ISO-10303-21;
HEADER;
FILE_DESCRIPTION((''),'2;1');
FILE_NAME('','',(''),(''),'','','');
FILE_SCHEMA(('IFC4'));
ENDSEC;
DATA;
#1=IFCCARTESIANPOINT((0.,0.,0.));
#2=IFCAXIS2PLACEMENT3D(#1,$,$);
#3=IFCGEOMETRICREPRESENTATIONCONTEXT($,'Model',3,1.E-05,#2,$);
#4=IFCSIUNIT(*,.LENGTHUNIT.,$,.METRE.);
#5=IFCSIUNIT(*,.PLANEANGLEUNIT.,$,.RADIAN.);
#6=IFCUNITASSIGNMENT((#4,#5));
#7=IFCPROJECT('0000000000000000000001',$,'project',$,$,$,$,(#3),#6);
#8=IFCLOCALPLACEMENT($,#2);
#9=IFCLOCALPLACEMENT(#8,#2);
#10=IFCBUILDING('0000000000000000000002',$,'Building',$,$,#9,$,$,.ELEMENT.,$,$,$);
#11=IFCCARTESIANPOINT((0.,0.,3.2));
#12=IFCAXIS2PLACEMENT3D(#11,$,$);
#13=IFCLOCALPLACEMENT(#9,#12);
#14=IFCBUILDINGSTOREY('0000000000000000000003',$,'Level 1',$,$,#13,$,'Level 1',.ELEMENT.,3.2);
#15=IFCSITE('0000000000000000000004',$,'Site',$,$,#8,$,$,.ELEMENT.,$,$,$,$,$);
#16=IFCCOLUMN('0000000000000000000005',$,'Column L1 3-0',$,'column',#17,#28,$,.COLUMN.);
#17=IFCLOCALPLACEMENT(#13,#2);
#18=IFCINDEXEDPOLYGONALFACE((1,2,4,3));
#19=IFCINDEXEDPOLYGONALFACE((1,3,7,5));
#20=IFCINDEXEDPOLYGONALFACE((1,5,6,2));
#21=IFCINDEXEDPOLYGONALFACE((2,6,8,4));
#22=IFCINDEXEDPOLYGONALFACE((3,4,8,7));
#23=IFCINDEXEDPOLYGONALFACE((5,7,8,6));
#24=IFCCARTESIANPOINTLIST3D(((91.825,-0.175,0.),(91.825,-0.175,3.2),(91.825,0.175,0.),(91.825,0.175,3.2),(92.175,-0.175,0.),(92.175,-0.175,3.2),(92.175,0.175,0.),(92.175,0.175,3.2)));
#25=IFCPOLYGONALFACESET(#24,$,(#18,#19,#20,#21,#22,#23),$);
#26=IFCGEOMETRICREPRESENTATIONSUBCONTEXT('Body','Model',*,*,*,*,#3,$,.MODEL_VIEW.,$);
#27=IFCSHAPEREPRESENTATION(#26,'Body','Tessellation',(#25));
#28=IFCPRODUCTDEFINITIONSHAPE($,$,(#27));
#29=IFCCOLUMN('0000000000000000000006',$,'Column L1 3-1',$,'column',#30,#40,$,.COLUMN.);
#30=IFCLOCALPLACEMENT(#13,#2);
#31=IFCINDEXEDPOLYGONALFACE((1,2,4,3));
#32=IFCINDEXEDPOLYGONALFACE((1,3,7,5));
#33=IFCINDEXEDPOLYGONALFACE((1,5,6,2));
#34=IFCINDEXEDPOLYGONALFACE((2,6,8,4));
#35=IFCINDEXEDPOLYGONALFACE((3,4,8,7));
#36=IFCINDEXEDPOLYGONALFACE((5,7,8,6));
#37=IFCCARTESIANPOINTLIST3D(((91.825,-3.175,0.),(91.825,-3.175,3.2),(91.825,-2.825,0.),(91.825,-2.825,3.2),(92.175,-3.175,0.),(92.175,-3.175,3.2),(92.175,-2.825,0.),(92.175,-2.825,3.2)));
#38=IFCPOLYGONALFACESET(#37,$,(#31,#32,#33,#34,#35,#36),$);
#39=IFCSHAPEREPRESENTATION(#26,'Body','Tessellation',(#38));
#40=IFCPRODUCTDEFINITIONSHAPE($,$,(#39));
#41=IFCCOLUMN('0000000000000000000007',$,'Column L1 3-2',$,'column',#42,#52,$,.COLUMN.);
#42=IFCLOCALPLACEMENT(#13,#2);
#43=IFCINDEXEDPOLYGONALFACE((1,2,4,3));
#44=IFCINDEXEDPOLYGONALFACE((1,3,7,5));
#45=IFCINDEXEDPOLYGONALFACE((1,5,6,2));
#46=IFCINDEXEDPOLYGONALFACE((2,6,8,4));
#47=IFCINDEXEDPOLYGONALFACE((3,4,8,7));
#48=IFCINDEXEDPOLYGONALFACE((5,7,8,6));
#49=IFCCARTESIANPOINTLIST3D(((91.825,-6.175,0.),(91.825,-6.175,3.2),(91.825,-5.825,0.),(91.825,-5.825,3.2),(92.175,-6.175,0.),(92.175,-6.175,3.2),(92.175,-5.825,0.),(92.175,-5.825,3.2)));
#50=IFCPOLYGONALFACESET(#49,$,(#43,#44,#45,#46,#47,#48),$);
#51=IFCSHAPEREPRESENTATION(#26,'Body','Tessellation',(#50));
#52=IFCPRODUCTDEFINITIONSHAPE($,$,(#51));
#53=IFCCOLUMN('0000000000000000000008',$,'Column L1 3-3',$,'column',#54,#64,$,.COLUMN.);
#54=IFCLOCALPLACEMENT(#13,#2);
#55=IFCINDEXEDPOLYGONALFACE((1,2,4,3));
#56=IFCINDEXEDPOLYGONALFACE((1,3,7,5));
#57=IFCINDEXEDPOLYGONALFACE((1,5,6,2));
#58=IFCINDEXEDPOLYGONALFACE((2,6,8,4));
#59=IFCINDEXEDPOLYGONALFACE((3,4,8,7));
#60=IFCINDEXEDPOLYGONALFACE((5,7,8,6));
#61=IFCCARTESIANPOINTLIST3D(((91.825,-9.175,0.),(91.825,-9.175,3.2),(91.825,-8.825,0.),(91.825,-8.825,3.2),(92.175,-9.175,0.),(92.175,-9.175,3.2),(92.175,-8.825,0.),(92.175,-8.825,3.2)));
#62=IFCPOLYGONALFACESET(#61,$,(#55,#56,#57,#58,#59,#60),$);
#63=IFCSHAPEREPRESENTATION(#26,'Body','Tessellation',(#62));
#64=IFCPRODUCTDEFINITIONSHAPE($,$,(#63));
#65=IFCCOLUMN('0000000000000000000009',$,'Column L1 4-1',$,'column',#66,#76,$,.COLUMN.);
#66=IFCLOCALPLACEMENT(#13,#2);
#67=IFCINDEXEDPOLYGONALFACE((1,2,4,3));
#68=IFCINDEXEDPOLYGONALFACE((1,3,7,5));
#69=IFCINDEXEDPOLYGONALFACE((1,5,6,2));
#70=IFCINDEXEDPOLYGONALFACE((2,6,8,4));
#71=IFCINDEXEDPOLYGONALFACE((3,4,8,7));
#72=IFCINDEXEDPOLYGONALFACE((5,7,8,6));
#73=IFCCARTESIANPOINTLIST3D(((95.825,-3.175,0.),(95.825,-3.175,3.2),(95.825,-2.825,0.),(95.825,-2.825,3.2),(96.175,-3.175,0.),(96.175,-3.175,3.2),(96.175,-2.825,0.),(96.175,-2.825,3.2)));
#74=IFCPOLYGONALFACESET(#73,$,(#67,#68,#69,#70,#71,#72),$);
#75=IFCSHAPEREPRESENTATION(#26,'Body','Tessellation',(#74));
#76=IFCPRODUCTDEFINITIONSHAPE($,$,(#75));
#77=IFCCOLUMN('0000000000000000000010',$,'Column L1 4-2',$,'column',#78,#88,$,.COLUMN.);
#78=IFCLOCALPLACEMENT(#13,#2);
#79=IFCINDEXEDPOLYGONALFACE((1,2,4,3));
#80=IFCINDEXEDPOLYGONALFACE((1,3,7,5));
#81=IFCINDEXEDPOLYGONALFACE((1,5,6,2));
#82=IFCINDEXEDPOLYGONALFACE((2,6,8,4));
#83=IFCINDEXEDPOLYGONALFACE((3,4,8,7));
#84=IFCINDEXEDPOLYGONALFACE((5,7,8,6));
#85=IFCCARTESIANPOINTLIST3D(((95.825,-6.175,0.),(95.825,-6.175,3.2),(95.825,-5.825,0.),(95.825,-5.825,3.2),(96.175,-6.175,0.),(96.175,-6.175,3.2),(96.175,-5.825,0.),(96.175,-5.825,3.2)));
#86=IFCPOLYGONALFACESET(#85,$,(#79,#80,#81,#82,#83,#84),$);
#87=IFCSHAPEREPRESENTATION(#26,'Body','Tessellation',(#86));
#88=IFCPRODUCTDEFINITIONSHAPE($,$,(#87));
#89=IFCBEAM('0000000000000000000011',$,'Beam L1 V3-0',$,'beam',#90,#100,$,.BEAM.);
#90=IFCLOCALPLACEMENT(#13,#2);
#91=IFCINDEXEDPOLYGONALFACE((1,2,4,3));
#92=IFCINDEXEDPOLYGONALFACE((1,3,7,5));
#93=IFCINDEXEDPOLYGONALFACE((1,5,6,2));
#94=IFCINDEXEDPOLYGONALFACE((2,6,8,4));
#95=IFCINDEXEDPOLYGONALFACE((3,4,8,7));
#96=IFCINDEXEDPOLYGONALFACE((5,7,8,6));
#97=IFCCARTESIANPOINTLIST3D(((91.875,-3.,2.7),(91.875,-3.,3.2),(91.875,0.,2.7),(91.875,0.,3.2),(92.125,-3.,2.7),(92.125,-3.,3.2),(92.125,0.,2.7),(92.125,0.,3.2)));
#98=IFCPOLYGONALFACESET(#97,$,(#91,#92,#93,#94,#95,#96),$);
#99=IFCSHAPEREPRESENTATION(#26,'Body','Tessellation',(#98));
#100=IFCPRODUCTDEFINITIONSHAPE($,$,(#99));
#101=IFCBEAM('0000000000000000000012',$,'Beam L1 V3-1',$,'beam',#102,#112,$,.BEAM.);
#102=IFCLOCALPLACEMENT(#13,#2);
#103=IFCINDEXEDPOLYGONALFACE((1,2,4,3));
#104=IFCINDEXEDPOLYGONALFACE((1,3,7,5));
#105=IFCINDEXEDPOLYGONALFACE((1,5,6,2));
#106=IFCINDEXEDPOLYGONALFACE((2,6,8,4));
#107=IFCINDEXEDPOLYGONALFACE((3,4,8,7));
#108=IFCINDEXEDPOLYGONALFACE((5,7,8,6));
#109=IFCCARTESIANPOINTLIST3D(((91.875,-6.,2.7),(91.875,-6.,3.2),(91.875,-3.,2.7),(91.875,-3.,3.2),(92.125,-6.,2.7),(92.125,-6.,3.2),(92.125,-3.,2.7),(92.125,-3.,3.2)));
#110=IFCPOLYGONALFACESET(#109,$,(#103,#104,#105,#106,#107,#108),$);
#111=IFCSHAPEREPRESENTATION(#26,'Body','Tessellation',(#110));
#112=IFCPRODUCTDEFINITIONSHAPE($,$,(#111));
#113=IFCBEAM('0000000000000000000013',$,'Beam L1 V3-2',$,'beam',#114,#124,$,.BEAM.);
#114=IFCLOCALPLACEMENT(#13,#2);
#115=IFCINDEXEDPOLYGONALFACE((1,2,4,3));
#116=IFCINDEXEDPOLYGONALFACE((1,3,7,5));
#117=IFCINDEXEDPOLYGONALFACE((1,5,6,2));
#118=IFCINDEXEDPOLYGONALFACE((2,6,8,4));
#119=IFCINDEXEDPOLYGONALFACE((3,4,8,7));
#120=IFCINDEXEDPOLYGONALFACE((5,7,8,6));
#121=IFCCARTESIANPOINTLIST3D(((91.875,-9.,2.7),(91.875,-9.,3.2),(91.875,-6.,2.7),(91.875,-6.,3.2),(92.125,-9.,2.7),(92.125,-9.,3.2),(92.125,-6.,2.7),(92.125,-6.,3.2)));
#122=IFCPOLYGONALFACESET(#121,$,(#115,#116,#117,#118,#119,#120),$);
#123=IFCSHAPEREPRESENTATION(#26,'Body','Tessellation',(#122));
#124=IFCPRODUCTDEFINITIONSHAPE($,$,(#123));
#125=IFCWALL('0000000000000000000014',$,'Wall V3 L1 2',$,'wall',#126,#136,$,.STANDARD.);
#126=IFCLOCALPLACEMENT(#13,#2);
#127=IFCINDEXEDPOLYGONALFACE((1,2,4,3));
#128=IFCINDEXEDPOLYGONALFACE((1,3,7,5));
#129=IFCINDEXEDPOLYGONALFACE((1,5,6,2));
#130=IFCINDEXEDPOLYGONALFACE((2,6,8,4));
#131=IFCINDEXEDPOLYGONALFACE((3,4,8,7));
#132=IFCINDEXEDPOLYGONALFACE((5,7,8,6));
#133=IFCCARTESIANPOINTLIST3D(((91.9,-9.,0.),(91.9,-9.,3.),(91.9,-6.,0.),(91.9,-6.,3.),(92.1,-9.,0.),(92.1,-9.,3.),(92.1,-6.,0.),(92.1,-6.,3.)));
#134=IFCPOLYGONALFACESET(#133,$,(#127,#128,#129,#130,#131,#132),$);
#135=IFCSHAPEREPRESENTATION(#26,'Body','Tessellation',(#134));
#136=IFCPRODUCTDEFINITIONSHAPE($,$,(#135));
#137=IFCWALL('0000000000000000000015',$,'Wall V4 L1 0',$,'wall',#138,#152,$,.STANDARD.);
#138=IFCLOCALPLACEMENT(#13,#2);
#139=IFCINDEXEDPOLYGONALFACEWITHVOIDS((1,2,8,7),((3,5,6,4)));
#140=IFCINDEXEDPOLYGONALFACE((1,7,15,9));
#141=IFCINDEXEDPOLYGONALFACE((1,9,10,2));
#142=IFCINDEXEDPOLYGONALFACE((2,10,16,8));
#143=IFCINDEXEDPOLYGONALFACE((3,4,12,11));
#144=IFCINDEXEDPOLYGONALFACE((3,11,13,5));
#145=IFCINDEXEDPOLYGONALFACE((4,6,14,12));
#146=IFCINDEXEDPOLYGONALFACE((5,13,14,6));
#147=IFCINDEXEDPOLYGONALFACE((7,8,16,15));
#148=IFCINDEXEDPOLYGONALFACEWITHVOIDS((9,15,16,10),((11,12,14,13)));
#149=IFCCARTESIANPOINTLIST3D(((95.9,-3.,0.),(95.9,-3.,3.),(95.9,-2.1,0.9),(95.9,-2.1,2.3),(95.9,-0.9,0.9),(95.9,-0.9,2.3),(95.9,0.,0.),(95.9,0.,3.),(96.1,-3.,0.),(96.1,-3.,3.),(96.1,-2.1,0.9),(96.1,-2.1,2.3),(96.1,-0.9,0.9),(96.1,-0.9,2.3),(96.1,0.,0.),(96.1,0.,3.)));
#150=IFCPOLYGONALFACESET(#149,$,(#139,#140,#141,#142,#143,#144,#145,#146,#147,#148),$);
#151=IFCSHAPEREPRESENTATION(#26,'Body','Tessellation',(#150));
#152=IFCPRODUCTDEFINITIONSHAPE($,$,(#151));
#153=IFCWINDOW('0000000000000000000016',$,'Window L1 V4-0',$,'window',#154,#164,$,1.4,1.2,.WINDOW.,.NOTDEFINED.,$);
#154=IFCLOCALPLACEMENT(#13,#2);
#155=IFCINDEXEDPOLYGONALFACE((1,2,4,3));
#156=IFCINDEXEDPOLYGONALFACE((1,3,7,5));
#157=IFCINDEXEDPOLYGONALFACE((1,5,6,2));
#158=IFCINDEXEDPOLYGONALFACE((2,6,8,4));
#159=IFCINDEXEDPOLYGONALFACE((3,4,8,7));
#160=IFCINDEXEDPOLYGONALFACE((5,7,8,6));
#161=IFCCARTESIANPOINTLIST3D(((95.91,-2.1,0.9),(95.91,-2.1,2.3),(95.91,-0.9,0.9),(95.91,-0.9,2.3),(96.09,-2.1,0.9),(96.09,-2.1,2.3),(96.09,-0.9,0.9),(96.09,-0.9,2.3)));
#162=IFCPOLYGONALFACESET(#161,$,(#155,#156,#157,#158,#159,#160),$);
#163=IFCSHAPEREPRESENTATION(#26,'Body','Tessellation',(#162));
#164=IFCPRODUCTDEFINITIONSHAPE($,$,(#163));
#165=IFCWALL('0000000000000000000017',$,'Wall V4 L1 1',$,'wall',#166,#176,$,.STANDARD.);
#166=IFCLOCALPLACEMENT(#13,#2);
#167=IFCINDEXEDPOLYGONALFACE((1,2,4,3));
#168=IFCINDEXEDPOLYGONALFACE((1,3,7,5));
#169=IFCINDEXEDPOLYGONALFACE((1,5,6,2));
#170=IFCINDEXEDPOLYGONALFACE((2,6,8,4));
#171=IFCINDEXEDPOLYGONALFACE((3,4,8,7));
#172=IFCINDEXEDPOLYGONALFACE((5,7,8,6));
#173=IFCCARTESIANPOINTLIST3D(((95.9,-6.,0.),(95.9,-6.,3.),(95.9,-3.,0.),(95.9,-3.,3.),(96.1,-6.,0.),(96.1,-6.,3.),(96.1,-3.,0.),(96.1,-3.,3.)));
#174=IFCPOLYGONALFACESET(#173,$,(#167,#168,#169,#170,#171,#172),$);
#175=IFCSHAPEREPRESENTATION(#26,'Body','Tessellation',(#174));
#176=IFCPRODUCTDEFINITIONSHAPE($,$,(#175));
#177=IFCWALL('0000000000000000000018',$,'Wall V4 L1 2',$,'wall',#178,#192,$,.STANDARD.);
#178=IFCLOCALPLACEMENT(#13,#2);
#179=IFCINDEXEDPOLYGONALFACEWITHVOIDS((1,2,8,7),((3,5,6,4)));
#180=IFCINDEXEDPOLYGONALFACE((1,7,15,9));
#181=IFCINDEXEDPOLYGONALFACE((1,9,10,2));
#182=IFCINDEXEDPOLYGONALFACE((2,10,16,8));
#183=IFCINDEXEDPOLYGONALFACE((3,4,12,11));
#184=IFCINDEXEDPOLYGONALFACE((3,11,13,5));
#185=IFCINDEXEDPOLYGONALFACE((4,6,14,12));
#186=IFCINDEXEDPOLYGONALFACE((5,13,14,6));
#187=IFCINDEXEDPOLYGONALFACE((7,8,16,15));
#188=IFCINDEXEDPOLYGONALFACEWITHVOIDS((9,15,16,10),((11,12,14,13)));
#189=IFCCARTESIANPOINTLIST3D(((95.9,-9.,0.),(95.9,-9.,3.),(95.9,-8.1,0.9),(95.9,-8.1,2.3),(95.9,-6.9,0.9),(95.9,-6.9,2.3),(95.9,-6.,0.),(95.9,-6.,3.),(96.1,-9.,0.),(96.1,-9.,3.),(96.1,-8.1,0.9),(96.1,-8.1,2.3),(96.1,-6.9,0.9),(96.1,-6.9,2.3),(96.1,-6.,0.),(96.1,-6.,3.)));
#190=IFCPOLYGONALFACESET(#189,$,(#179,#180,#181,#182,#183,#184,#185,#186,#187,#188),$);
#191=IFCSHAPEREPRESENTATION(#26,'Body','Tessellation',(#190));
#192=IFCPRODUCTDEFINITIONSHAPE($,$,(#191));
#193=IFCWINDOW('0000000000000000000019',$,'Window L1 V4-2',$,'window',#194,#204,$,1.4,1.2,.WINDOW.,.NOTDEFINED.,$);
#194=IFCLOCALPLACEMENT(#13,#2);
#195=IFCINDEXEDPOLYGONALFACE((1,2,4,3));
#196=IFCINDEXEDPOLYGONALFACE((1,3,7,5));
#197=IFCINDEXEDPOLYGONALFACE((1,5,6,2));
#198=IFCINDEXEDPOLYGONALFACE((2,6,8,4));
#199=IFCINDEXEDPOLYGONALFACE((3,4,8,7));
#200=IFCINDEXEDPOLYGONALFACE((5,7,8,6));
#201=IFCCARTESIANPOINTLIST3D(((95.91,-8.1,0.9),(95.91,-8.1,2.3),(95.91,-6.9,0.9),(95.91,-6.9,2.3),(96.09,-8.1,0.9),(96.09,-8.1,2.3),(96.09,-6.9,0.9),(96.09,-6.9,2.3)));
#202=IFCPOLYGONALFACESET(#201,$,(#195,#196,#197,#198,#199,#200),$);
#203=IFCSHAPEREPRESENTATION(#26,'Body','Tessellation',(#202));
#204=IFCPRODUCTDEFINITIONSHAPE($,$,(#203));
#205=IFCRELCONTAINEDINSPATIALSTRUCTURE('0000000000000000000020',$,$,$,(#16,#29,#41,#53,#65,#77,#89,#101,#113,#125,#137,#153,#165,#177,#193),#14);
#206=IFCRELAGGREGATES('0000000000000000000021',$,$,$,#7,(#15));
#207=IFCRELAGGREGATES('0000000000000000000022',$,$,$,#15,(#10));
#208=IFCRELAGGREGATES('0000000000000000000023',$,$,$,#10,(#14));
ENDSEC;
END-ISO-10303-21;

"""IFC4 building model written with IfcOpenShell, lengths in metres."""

from ifc_helpers import new_model, si_unit, frame, frame_2d, origin, origin_2d, place, context, subcontext, project, spatial, rectangle, extrude, element, fill, save


model = new_model("IFC4")

# Units and contexts
model_context = context("Model", 3, precision=1e-05, world=origin())
body_context = subcontext(model_context, "Body", "Model", "MODEL_VIEW")
ifc_project = project(units=[si_unit("LENGTHUNIT", "METRE"), si_unit("PLANEANGLEUNIT", "RADIAN")], contexts=[model_context])

# Site, building, storey
site_placement = place(None, origin())
site = spatial("IfcSite", under=ifc_project, at=site_placement, Name="Site", CompositionType="ELEMENT")
building_placement = place(site_placement, origin())
building = spatial("IfcBuilding", under=site, at=building_placement, Name="Building", CompositionType="ELEMENT")
storey_placement = place(building_placement, frame((0.0, 0.0, 3.2)))
storey = spatial("IfcBuildingStorey", under=building, at=storey_placement, Name="Level 1", LongName="Level 1", CompositionType="ELEMENT", Elevation=3.2)

# Columns
for number, where, name in (
    (1, (92.0, 0.0, 0.0), "Column L1 3-0"),
    (2, (92.0, -3.0, 0.0), "Column L1 3-1"),
    (3, (92.0, -6.0, 0.0), "Column L1 3-2"),
    (4, (92.0, -9.0, 0.0), "Column L1 3-3"),
    (5, (96.0, -3.0, 0.0), "Column L1 4-1"),
    (6, (96.0, -6.0, 0.0), "Column L1 4-2"),
):
    element("IfcColumn", number, at=place(storey_placement, frame(where)), inside=storey, Name=name, ObjectType="column", PredefinedType="COLUMN", context=body_context, shape_type="SweptSolid", body=[
        extrude(rectangle(XDim=0.35, YDim=0.35, at=origin_2d()), origin(), (0.0, 0.0, 1.0), 3.2),
    ])

# Beams
for number, where, z_axis, x_axis, name in (
    (7, (92.0, 0.0, 2.95), (0.0, -1.0, 0.0), (0.0, 0.0, 1.0), "Beam L1 V3-0"),
    (8, (92.0, -3.0, 2.95), (0.0, -1.0, 0.0), (0.0, 0.0, 1.0), "Beam L1 V3-1"),
    (9, (92.0, -6.0, 2.95), (0.0, -1.0, 0.0), (0.0, 0.0, 1.0), "Beam L1 V3-2"),
):
    element("IfcBeam", number, at=place(storey_placement, frame(where, z_axis=z_axis, x_axis=x_axis)), inside=storey, Name=name, ObjectType="beam", PredefinedType="BEAM", context=body_context, shape_type="SweptSolid", body=[
        extrude(rectangle(XDim=0.5, YDim=0.25, at=origin_2d()), origin(), (0.0, 0.0, 1.0), 3.0),
    ])

# Wall
wall_1_placement = place(storey_placement, frame((92.0, -6.0, 0.0), z_axis=(0.0, 0.0, 1.0), x_axis=(0.0, -1.0, 0.0)))
element("IfcWall", 10, at=wall_1_placement, inside=storey, Name="Wall V3 L1 2", ObjectType="wall", PredefinedType="STANDARD", context=body_context, shape_type="SweptSolid", body=[
    extrude(rectangle(XDim=3.0, YDim=0.2, at=frame_2d((1.5, 0.0))), origin(), (0.0, 0.0, 1.0), 3.0),
])

# Wall, opening, window
wall_2_placement = place(storey_placement, frame((96.0, 0.0, 0.0), z_axis=(0.0, 0.0, 1.0), x_axis=(0.0, -1.0, 0.0)))
wall_2 = element("IfcWall", 11, at=wall_2_placement, inside=storey, Name="Wall V4 L1 0", ObjectType="wall", PredefinedType="STANDARD", context=body_context, shape_type="SweptSolid", body=[
    extrude(rectangle(XDim=3.0, YDim=0.2, at=frame_2d((1.5, 0.0))), origin(), (0.0, 0.0, 1.0), 3.0),
])
opening_1_placement = place(storey_placement, frame((96.0, -1.5, 0.9), z_axis=(0.0, 0.0, 1.0), x_axis=(0.0, -1.0, 0.0)))
opening_1 = element("IfcOpeningElement", 12, at=opening_1_placement, cuts=wall_2, ObjectType="Opening", PredefinedType="OPENING", context=body_context, shape_type="SweptSolid", body=[
    extrude(rectangle(XDim=1.2, YDim=0.22, at=origin_2d()), origin(), (0.0, 0.0, 1.0), 1.4),
])
window_1_placement = place(storey_placement, frame((96.0, -1.5, 0.9), z_axis=(0.0, 0.0, 1.0), x_axis=(0.0, -1.0, 0.0)))
window_1 = element("IfcWindow", 13, at=window_1_placement, inside=storey, Name="Window L1 V4-0", ObjectType="window", OverallHeight=1.4, OverallWidth=1.2, PartitioningType="NOTDEFINED", PredefinedType="WINDOW", context=body_context, shape_type="SweptSolid", body=[
    extrude(rectangle(XDim=1.2, YDim=0.18, at=origin_2d()), origin(), (0.0, 0.0, 1.0), 1.4),
])
fill(opening_1, window_1)

# Wall
wall_3_placement = place(storey_placement, frame((96.0, -3.0, 0.0), z_axis=(0.0, 0.0, 1.0), x_axis=(0.0, -1.0, 0.0)))
element("IfcWall", 14, at=wall_3_placement, inside=storey, Name="Wall V4 L1 1", ObjectType="wall", PredefinedType="STANDARD", context=body_context, shape_type="SweptSolid", body=[
    extrude(rectangle(XDim=3.0, YDim=0.2, at=frame_2d((1.5, 0.0))), origin(), (0.0, 0.0, 1.0), 3.0),
])

# Wall, opening, window
wall_4_placement = place(storey_placement, frame((96.0, -6.0, 0.0), z_axis=(0.0, 0.0, 1.0), x_axis=(0.0, -1.0, 0.0)))
wall_4 = element("IfcWall", 15, at=wall_4_placement, inside=storey, Name="Wall V4 L1 2", ObjectType="wall", PredefinedType="STANDARD", context=body_context, shape_type="SweptSolid", body=[
    extrude(rectangle(XDim=3.0, YDim=0.2, at=frame_2d((1.5, 0.0))), origin(), (0.0, 0.0, 1.0), 3.0),
])
opening_2_placement = place(storey_placement, frame((96.0, -7.5, 0.9), z_axis=(0.0, 0.0, 1.0), x_axis=(0.0, -1.0, 0.0)))
opening_2 = element("IfcOpeningElement", 16, at=opening_2_placement, cuts=wall_4, ObjectType="Opening", PredefinedType="OPENING", context=body_context, shape_type="SweptSolid", body=[
    extrude(rectangle(XDim=1.2, YDim=0.22, at=origin_2d()), origin(), (0.0, 0.0, 1.0), 1.4),
])
window_2_placement = place(storey_placement, frame((96.0, -7.5, 0.9), z_axis=(0.0, 0.0, 1.0), x_axis=(0.0, -1.0, 0.0)))
window_2 = element("IfcWindow", 17, at=window_2_placement, inside=storey, Name="Window L1 V4-2", ObjectType="window", OverallHeight=1.4, OverallWidth=1.2, PartitioningType="NOTDEFINED", PredefinedType="WINDOW", context=body_context, shape_type="SweptSolid", body=[
    extrude(rectangle(XDim=1.2, YDim=0.18, at=origin_2d()), origin(), (0.0, 0.0, 1.0), 1.4),
])
fill(opening_2, window_2)

save(model, "model.ifc")
